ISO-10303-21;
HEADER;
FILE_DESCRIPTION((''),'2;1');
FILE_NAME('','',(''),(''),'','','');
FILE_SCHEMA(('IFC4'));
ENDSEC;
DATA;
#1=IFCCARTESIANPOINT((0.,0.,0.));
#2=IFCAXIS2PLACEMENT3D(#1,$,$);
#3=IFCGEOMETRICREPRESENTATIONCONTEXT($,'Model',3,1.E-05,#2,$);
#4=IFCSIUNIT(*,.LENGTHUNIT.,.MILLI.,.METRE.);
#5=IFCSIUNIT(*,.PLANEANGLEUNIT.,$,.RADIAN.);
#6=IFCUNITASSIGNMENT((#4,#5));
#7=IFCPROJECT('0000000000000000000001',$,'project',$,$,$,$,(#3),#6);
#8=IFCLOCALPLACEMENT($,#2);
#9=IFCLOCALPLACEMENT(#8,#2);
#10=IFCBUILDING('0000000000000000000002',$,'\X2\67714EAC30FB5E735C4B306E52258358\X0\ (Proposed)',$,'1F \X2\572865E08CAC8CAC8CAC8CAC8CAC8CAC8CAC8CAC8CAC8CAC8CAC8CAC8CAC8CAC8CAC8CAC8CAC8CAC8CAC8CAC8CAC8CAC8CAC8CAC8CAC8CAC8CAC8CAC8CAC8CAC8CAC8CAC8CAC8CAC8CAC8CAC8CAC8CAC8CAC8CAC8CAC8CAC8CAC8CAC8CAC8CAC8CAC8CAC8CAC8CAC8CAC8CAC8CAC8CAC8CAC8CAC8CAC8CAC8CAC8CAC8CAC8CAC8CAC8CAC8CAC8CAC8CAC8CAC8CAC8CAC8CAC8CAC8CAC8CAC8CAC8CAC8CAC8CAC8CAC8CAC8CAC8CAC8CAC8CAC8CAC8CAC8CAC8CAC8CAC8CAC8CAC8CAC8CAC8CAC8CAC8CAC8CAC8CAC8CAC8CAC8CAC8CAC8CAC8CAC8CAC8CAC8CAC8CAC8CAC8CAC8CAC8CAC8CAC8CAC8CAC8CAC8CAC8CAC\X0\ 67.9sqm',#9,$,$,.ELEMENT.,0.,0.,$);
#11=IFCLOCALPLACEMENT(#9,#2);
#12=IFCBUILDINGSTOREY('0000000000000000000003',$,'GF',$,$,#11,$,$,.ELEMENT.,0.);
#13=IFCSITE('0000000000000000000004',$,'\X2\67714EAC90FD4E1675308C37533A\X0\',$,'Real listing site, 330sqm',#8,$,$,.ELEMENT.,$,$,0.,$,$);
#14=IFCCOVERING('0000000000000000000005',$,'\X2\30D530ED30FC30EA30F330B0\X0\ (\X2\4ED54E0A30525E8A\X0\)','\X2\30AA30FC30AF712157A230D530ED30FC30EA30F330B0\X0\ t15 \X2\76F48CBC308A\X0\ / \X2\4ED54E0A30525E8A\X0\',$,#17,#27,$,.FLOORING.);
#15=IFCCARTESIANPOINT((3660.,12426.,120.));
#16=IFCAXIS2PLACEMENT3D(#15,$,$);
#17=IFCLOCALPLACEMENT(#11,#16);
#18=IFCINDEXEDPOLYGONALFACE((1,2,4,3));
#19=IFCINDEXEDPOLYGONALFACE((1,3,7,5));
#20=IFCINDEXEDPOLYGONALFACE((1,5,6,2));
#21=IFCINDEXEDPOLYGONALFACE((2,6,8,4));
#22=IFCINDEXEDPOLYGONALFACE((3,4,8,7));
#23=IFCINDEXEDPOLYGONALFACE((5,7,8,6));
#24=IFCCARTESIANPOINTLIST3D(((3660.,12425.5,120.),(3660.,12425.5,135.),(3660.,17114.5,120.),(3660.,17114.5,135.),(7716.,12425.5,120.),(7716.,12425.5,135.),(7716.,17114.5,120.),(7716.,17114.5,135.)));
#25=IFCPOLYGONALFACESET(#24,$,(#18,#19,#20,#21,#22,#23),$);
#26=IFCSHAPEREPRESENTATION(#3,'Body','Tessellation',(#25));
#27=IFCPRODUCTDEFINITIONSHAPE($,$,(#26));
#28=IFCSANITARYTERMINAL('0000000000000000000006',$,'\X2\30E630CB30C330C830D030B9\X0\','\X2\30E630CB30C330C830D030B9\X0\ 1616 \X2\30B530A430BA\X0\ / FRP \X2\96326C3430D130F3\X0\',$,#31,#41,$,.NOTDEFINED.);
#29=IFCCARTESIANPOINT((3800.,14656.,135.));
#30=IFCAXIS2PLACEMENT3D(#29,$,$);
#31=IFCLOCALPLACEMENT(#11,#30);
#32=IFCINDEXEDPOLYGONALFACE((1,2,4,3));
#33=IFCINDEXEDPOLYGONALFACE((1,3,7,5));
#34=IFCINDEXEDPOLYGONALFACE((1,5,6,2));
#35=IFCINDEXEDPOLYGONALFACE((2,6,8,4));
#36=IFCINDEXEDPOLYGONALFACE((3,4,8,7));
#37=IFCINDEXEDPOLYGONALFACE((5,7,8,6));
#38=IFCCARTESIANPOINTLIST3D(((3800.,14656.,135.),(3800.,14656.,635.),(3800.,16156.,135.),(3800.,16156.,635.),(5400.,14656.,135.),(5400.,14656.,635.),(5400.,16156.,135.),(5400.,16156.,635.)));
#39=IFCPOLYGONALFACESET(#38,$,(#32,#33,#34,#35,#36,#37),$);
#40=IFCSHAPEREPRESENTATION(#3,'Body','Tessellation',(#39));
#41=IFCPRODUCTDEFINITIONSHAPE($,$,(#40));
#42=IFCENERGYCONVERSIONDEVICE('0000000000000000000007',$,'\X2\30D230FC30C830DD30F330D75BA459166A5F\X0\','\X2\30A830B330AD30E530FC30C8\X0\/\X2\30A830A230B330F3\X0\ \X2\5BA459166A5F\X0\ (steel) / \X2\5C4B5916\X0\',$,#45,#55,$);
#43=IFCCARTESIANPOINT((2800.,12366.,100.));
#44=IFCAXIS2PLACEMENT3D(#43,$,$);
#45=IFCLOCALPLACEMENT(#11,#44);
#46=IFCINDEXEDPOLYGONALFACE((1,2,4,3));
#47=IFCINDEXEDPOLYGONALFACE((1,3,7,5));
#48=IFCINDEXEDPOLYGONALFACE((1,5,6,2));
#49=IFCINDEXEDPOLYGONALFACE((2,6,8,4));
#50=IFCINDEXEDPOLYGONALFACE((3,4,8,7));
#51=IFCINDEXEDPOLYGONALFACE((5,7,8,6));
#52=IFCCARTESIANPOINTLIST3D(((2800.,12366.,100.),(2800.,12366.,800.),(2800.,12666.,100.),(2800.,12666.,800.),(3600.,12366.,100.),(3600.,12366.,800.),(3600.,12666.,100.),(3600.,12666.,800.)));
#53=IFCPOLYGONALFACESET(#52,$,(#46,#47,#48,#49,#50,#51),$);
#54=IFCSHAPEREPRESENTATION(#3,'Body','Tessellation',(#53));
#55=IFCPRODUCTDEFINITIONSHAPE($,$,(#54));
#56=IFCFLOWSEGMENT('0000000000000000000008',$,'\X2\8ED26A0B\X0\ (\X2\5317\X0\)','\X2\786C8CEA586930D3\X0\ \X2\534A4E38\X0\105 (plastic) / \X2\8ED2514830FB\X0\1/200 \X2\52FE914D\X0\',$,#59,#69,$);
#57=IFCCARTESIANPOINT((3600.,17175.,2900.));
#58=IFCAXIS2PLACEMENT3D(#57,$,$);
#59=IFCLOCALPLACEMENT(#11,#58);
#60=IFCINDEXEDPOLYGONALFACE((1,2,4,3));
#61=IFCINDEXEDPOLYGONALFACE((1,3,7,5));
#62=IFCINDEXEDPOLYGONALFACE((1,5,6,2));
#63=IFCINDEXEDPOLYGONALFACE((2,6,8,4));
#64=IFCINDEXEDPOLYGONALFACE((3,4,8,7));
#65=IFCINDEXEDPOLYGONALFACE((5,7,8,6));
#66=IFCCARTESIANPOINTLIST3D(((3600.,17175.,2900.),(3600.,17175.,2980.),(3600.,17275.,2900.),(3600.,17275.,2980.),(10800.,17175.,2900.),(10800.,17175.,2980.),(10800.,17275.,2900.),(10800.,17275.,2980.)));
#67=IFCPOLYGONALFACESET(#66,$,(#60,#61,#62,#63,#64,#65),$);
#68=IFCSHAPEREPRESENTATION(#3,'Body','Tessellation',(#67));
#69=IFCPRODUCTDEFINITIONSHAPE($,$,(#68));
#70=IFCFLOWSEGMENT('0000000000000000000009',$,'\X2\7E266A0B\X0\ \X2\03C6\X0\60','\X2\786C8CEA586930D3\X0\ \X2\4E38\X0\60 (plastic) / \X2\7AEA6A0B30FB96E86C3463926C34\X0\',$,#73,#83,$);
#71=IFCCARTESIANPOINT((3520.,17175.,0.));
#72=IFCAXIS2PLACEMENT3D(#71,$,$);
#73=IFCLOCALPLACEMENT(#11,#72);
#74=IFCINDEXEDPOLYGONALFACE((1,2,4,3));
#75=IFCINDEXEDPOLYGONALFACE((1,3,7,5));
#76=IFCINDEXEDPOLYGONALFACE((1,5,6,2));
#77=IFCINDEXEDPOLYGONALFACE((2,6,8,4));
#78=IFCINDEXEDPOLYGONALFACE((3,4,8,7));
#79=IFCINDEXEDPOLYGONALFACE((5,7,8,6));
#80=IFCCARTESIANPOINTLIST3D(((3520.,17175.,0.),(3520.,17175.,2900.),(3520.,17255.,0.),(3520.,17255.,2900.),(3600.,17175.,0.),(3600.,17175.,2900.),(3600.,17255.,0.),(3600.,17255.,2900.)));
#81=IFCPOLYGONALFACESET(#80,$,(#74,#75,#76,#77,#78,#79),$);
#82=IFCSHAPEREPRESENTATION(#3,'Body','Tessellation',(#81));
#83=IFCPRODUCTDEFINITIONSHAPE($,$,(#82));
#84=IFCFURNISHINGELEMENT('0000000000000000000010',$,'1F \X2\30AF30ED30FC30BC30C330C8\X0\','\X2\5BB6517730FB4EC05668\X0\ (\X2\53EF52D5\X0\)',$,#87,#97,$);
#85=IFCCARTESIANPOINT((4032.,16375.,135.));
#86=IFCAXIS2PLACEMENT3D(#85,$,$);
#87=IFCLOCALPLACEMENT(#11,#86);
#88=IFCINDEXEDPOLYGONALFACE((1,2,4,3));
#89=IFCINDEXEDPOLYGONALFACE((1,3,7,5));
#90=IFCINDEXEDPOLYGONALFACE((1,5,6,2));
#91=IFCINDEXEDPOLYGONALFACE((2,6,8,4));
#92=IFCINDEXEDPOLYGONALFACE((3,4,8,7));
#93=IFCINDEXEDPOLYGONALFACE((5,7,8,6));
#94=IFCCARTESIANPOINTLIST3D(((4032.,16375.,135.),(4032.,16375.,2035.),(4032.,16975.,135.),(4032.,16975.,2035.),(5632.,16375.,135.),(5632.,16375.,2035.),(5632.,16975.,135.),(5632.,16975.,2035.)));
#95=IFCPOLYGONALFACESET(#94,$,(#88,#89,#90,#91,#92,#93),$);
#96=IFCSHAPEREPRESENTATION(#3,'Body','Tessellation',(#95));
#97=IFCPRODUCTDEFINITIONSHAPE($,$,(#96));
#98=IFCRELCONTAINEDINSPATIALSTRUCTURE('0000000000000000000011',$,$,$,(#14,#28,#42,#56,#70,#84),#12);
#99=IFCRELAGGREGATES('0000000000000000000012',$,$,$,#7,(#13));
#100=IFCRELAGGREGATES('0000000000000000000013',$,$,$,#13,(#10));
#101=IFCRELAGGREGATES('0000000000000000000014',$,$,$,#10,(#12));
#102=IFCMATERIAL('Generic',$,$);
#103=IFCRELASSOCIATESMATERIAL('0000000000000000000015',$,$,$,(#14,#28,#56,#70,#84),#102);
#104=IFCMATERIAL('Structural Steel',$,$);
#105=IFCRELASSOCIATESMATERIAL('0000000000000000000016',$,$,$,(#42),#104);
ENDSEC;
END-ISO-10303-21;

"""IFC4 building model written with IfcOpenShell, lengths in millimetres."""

from ifc_helpers import new_model, si_unit, frame, frame_2d, origin, place, context, project, spatial, rectangle, extrude, material, element, save


model = new_model("IFC4")

# Units and contexts
model_context = context("Model", 3, precision=1e-05, world=origin())
ifc_project = project(units=[si_unit("LENGTHUNIT", "METRE", prefix="MILLI"), si_unit("PLANEANGLEUNIT", "RADIAN")], contexts=[model_context])

# Site, building, storey
site_placement = place(None, origin())
site = spatial("IfcSite", under=ifc_project, at=site_placement, Name="東京都世田谷区", ObjectType="Real listing site, 330sqm", CompositionType="ELEMENT", RefElevation=0.0)
building_placement = place(site_placement, origin())
building = spatial("IfcBuilding", under=site, at=building_placement, Name="東京・平屋の別荘 (Proposed)", ObjectType="1F 在无責責責責責責責責責責責責責責責責責責責責責責責責責責責責責責責責責責責責責責責責責責責責責責責責責責責責責責責責責責責責責責責責責責責責責責責責責責責責責責責責責責責責責責責責責責責責責責責責責責責責責責責責責責責責責責責責責責責責責責 67.9sqm", CompositionType="ELEMENT", ElevationOfRefHeight=0.0, ElevationOfTerrain=0.0)
storey_placement = place(building_placement, origin())
storey = spatial("IfcBuildingStorey", under=building, at=storey_placement, Name="GF", CompositionType="ELEMENT", Elevation=0.0)

# Shared definitions
ifc_material_1 = material(Name="Structural Steel")

# Covering
ifc_material_2 = material(Name="Generic")
covering_placement = place(storey_placement, frame((3660.0, 12426.0, 120.0)))
element("IfcCovering", 1, at=covering_placement, inside=storey, material=ifc_material_2, Name="フローリング (仕上げ床)", Description="オーク無垢フローリング t15 直貼り / 仕上げ床", PredefinedType="FLOORING", context=model_context, shape_type="SweptSolid", body=[
    extrude(rectangle(XDim=4056.0, YDim=4689.0, at=frame_2d((2028.0, 2344.0))), frame((3660.0, 12426.0, 120.0)), (0.0, 0.0, 1.0), 15.0),
])

# Sanitary terminal
sanitary_terminal_placement = place(storey_placement, frame((3800.0, 14656.0, 135.0)))
element("IfcSanitaryTerminal", 2, at=sanitary_terminal_placement, inside=storey, material=ifc_material_2, Name="ユニットバス", Description="ユニットバス 1616 サイズ / FRP 防水パン", PredefinedType="NOTDEFINED", context=model_context, shape_type="SweptSolid", body=[
    extrude(rectangle(XDim=1600.0, YDim=1500.0, at=frame_2d((800.0, 750.0))), frame((3800.0, 14656.0, 135.0)), (0.0, 0.0, 1.0), 500.0),
])

# Energy conversion device
energy_conversion_device_placement = place(storey_placement, frame((2800.0, 12366.0, 100.0)))
element("IfcEnergyConversionDevice", 3, at=energy_conversion_device_placement, inside=storey, material=ifc_material_1, Name="ヒートポンプ室外機", Description="エコキュート/エアコン 室外機 (steel) / 屋外", context=model_context, shape_type="SweptSolid", body=[
    extrude(rectangle(XDim=800.0, YDim=300.0, at=frame_2d((400.0, 150.0))), frame((2800.0, 12366.0, 100.0)), (0.0, 0.0, 1.0), 700.0),
])

# Flow segments
flow_segment_1_placement = place(storey_placement, frame((3600.0, 17175.0, 2900.0)))
element("IfcFlowSegment", 4, at=flow_segment_1_placement, inside=storey, material=ifc_material_2, Name="軒樋 (北)", Description="硬質塩ビ 半丸105 (plastic) / 軒先・1/200 勾配", context=model_context, shape_type="SweptSolid", body=[
    extrude(rectangle(XDim=7200.0, YDim=100.0, at=frame_2d((3600.0, 50.0))), frame((3600.0, 17175.0, 2900.0)), (0.0, 0.0, 1.0), 80.0),
])
flow_segment_2_placement = place(storey_placement, frame((3520.0, 17175.0, 0.0)))
element("IfcFlowSegment", 5, at=flow_segment_2_placement, inside=storey, material=ifc_material_2, Name="縦樋 φ60", Description="硬質塩ビ 丸60 (plastic) / 竪樋・雨水排水", context=model_context, shape_type="SweptSolid", body=[
    extrude(rectangle(XDim=80.0, YDim=80.0, at=frame_2d((40.0, 40.0))), frame((3520.0, 17175.0, 0.0)), (0.0, 0.0, 1.0), 2900.0),
])

# Furnishing element
furnishing_placement = place(storey_placement, frame((4032.0, 16375.0, 135.0)))
element("IfcFurnishingElement", 6, at=furnishing_placement, inside=storey, material=ifc_material_2, Name="1F クローゼット", Description="家具・什器 (可動)", context=model_context, shape_type="SweptSolid", body=[
    extrude(rectangle(XDim=1600.0, YDim=600.0, at=frame_2d((800.0, 300.0))), frame((4032.0, 16375.0, 135.0)), (0.0, 0.0, 1.0), 1900.0),
])

save(model, "model.ifc")
